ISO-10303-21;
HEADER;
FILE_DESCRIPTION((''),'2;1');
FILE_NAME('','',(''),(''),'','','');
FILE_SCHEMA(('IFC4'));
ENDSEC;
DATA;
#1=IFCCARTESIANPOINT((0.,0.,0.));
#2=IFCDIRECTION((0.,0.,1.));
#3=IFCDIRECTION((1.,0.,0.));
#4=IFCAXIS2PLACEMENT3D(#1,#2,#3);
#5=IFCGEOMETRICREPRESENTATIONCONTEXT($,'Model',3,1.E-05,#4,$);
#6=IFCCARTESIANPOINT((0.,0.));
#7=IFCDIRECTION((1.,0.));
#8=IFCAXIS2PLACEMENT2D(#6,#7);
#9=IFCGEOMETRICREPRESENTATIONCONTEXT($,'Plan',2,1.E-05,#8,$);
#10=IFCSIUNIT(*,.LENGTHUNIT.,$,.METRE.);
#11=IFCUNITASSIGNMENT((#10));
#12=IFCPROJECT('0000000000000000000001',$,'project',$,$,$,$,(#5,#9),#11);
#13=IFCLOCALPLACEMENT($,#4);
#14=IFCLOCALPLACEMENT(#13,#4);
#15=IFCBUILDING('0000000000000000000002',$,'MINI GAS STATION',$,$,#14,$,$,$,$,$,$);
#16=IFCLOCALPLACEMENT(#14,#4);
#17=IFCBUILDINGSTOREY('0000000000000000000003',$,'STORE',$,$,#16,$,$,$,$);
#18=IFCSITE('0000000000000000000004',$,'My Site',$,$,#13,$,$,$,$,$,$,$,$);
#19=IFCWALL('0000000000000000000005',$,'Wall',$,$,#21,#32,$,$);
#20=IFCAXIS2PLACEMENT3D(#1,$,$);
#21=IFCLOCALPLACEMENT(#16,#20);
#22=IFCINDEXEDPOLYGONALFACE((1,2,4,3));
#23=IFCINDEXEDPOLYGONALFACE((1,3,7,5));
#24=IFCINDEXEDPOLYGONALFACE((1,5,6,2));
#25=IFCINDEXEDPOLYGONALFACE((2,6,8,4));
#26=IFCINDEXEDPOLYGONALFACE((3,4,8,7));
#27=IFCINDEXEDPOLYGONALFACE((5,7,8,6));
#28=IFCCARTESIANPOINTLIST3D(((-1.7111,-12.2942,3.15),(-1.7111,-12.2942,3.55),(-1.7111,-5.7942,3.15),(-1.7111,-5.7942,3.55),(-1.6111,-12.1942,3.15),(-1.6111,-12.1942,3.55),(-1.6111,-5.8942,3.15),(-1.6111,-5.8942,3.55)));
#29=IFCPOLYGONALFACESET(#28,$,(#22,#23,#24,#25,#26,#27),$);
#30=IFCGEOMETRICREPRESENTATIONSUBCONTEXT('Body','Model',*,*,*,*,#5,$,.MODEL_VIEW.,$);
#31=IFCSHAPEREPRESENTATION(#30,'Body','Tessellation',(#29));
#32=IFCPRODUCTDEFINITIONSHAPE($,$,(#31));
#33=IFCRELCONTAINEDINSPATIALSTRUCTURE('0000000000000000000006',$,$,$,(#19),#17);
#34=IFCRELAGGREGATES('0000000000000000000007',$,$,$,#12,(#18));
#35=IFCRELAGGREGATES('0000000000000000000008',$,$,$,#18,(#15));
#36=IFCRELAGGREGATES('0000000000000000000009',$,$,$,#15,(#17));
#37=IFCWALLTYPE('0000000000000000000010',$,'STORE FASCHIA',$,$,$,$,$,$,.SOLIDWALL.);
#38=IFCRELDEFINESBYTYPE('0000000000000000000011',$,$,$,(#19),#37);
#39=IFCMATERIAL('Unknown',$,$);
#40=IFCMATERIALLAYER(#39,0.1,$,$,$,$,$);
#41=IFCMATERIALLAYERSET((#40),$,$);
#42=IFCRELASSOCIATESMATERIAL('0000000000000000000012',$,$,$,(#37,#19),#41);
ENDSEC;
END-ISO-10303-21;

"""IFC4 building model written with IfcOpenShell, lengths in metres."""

from ifc_helpers import new_model, si_unit, frame, origin_with_axes, origin_2d_with_axis, place, context, subcontext, project, spatial, line, indexed_curve, outline, extrude, material, layer, layer_set, layer_usage, type_object, element, save


model = new_model("IFC4")

# Units and contexts
model_context = context("Model", 3, precision=1e-05, world=origin_with_axes())
plan_context = context("Plan", 2, precision=1e-05, world=origin_2d_with_axis())
body_context_1 = subcontext(model_context, "Body", "Model", "MODEL_VIEW")
ifc_project = project(units=[si_unit("LENGTHUNIT", "METRE")], contexts=[model_context, plan_context])

# Site, building, storey
site_placement = place(None, origin_with_axes())
site = spatial("IfcSite", under=ifc_project, at=site_placement, Name="My Site")
building_placement = place(site_placement, origin_with_axes())
building = spatial("IfcBuilding", under=site, at=building_placement, Name="MINI GAS STATION")
storey_placement = place(building_placement, origin_with_axes())
storey = spatial("IfcBuildingStorey", under=building, at=storey_placement, Name="STORE")

# Shared definitions
ifc_material = material(Name="Unknown")

# Wall
ifc_layer_1 = layer(ifc_material, 0.1)
ifc_layer_set_1 = layer_set([ifc_layer_1])
wall_type_1 = type_object("IfcWallType", Name="STORE FASCHIA", PredefinedType="SOLIDWALL", material=ifc_layer_set_1)
ifc_layer_usage_1 = layer_usage(ifc_layer_set_1, "AXIS2", "POSITIVE", 0.0)
wall_1_placement = place(storey_placement, frame((-1.6111, -12.1942, 3.15), z_axis=(0.0, 0.0, 1.0), x_axis=(0.0, 1.0, 0.0)))
element("IfcWall", 1, at=wall_1_placement, inside=storey, type_object=wall_type_1, material=ifc_layer_usage_1, Name="Wall", context=body_context_1, shape_type="SweptSolid", body=[
    extrude(outline(indexed_curve([(0.0, 0.0), (-0.1, 0.1), (6.4, 0.1), (6.3, 0.0)], segments=[line(1, 2, 3, 4, 1)])), origin_with_axes(), (0.0, 0.0, 1.0), 0.4),
])

save(model, "model.ifc")
